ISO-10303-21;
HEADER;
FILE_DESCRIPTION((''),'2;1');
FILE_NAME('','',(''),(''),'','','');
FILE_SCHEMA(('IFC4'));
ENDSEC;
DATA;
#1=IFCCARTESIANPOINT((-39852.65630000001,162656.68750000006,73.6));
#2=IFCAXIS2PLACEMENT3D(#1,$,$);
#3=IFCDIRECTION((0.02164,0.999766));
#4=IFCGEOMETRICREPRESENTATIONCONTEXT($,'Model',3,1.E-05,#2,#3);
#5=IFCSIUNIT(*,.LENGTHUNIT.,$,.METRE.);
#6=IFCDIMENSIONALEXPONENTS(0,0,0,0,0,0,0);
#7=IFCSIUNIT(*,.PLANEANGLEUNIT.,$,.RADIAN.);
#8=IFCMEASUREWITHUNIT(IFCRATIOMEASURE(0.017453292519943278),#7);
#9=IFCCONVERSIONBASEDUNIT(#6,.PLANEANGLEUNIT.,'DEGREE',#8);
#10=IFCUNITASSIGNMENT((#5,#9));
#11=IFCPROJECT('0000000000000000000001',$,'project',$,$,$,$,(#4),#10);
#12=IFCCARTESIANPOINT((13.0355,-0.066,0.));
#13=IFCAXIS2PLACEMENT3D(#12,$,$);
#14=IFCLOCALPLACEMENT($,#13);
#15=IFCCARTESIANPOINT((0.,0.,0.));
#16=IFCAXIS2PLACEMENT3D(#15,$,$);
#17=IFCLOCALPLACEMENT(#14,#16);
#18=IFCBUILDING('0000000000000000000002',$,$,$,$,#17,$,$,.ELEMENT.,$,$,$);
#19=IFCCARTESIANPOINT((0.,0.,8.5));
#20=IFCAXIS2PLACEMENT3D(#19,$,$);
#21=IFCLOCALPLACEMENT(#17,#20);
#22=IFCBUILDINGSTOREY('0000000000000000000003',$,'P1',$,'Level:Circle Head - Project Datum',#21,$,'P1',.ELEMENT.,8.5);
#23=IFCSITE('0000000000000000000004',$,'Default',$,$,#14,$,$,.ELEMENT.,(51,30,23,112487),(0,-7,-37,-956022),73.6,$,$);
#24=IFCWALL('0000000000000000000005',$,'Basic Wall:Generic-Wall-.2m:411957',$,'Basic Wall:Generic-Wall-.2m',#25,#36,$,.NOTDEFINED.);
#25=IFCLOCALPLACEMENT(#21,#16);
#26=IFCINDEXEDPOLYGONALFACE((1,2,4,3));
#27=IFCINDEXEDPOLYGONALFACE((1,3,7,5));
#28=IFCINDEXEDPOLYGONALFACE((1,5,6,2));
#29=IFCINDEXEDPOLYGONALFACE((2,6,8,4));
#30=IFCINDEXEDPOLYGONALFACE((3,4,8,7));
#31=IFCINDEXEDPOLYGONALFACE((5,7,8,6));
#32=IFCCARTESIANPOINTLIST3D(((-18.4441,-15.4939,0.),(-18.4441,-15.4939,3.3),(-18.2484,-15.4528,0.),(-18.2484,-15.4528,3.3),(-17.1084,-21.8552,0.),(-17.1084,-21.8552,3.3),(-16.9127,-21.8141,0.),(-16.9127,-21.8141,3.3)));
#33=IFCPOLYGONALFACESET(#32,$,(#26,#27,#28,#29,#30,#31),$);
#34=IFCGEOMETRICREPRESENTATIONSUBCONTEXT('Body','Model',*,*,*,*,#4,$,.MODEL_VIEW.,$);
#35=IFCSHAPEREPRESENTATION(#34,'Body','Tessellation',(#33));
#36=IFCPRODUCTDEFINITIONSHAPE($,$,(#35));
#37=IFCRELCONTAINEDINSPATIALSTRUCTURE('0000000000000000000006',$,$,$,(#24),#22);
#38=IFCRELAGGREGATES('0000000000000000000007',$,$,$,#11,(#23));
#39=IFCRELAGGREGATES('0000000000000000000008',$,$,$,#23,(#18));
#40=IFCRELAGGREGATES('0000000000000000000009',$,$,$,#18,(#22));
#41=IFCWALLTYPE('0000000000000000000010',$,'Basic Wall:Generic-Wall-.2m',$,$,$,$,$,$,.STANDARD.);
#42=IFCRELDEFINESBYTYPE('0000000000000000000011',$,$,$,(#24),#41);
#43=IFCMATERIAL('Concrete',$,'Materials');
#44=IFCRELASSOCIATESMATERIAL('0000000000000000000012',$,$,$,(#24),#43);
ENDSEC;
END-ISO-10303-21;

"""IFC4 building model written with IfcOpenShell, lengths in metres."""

from ifc_helpers import new_model, entity, si_unit, converted_unit, direction, frame, origin, place, context, subcontext, project, spatial, indexed_curve, outline, extrude, material, type_object, element, save


model = new_model("IFC4")

# Units and contexts
model_context = context("Model", 3, precision=1e-05, world=frame((-39852.65630000001, 162656.68750000006, 73.6)), true_north=direction((0.02164, 0.999766)))
body_context = subcontext(model_context, "Body", "Model", "MODEL_VIEW")
ifc_project = project(units=[si_unit("LENGTHUNIT", "METRE"), converted_unit("PLANEANGLEUNIT", "DEGREE", entity("IfcRatioMeasure", 0.017453292519943278), si_unit("PLANEANGLEUNIT", "RADIAN"), dimensions=[0, 0, 0, 0, 0, 0, 0])], contexts=[model_context])

# Site, building, storey
site_placement = place(None, frame((13.0355, -0.066, 0.0)))
site = spatial("IfcSite", under=ifc_project, at=site_placement, Name="Default", CompositionType="ELEMENT", RefLatitude=(51, 30, 23, 112487), RefLongitude=(0, -7, -37, -956022), RefElevation=73.6)
building_placement = place(site_placement, origin())
building = spatial("IfcBuilding", under=site, at=building_placement, CompositionType="ELEMENT")
storey_placement = place(building_placement, frame((0.0, 0.0, 8.5)))
storey = spatial("IfcBuildingStorey", under=building, at=storey_placement, Name="P1", ObjectType="Level:Circle Head - Project Datum", LongName="P1", CompositionType="ELEMENT", Elevation=8.5)

# Shared definitions
ifc_material = material(Name="Concrete", Category="Materials")

# Wall
wall_type_1 = type_object("IfcWallType", Name="Basic Wall:Generic-Wall-.2m", PredefinedType="STANDARD")
wall_1_placement = place(storey_placement, frame((-18.3463, -15.4734, 0.0), z_axis=(0.0, 0.0, 1.0), x_axis=(0.2055, -0.978657, 0.0)))
element("IfcWall", 1, at=wall_1_placement, inside=storey, type_object=wall_type_1, material=ifc_material, Name="Basic Wall:Generic-Wall-.2m:411957", ObjectType="Basic Wall:Generic-Wall-.2m", PredefinedType="NOTDEFINED", context=body_context, shape_type="SweptSolid", body=[
    extrude(outline(indexed_curve([(6.5, 0.1), (0.0, 0.1), (0.0, -0.1), (6.5, -0.1), (6.5, 0.1)], self_intersect=False)), origin(), (0.0, 0.0, 1.0), 3.3),
])

save(model, "model.ifc")
